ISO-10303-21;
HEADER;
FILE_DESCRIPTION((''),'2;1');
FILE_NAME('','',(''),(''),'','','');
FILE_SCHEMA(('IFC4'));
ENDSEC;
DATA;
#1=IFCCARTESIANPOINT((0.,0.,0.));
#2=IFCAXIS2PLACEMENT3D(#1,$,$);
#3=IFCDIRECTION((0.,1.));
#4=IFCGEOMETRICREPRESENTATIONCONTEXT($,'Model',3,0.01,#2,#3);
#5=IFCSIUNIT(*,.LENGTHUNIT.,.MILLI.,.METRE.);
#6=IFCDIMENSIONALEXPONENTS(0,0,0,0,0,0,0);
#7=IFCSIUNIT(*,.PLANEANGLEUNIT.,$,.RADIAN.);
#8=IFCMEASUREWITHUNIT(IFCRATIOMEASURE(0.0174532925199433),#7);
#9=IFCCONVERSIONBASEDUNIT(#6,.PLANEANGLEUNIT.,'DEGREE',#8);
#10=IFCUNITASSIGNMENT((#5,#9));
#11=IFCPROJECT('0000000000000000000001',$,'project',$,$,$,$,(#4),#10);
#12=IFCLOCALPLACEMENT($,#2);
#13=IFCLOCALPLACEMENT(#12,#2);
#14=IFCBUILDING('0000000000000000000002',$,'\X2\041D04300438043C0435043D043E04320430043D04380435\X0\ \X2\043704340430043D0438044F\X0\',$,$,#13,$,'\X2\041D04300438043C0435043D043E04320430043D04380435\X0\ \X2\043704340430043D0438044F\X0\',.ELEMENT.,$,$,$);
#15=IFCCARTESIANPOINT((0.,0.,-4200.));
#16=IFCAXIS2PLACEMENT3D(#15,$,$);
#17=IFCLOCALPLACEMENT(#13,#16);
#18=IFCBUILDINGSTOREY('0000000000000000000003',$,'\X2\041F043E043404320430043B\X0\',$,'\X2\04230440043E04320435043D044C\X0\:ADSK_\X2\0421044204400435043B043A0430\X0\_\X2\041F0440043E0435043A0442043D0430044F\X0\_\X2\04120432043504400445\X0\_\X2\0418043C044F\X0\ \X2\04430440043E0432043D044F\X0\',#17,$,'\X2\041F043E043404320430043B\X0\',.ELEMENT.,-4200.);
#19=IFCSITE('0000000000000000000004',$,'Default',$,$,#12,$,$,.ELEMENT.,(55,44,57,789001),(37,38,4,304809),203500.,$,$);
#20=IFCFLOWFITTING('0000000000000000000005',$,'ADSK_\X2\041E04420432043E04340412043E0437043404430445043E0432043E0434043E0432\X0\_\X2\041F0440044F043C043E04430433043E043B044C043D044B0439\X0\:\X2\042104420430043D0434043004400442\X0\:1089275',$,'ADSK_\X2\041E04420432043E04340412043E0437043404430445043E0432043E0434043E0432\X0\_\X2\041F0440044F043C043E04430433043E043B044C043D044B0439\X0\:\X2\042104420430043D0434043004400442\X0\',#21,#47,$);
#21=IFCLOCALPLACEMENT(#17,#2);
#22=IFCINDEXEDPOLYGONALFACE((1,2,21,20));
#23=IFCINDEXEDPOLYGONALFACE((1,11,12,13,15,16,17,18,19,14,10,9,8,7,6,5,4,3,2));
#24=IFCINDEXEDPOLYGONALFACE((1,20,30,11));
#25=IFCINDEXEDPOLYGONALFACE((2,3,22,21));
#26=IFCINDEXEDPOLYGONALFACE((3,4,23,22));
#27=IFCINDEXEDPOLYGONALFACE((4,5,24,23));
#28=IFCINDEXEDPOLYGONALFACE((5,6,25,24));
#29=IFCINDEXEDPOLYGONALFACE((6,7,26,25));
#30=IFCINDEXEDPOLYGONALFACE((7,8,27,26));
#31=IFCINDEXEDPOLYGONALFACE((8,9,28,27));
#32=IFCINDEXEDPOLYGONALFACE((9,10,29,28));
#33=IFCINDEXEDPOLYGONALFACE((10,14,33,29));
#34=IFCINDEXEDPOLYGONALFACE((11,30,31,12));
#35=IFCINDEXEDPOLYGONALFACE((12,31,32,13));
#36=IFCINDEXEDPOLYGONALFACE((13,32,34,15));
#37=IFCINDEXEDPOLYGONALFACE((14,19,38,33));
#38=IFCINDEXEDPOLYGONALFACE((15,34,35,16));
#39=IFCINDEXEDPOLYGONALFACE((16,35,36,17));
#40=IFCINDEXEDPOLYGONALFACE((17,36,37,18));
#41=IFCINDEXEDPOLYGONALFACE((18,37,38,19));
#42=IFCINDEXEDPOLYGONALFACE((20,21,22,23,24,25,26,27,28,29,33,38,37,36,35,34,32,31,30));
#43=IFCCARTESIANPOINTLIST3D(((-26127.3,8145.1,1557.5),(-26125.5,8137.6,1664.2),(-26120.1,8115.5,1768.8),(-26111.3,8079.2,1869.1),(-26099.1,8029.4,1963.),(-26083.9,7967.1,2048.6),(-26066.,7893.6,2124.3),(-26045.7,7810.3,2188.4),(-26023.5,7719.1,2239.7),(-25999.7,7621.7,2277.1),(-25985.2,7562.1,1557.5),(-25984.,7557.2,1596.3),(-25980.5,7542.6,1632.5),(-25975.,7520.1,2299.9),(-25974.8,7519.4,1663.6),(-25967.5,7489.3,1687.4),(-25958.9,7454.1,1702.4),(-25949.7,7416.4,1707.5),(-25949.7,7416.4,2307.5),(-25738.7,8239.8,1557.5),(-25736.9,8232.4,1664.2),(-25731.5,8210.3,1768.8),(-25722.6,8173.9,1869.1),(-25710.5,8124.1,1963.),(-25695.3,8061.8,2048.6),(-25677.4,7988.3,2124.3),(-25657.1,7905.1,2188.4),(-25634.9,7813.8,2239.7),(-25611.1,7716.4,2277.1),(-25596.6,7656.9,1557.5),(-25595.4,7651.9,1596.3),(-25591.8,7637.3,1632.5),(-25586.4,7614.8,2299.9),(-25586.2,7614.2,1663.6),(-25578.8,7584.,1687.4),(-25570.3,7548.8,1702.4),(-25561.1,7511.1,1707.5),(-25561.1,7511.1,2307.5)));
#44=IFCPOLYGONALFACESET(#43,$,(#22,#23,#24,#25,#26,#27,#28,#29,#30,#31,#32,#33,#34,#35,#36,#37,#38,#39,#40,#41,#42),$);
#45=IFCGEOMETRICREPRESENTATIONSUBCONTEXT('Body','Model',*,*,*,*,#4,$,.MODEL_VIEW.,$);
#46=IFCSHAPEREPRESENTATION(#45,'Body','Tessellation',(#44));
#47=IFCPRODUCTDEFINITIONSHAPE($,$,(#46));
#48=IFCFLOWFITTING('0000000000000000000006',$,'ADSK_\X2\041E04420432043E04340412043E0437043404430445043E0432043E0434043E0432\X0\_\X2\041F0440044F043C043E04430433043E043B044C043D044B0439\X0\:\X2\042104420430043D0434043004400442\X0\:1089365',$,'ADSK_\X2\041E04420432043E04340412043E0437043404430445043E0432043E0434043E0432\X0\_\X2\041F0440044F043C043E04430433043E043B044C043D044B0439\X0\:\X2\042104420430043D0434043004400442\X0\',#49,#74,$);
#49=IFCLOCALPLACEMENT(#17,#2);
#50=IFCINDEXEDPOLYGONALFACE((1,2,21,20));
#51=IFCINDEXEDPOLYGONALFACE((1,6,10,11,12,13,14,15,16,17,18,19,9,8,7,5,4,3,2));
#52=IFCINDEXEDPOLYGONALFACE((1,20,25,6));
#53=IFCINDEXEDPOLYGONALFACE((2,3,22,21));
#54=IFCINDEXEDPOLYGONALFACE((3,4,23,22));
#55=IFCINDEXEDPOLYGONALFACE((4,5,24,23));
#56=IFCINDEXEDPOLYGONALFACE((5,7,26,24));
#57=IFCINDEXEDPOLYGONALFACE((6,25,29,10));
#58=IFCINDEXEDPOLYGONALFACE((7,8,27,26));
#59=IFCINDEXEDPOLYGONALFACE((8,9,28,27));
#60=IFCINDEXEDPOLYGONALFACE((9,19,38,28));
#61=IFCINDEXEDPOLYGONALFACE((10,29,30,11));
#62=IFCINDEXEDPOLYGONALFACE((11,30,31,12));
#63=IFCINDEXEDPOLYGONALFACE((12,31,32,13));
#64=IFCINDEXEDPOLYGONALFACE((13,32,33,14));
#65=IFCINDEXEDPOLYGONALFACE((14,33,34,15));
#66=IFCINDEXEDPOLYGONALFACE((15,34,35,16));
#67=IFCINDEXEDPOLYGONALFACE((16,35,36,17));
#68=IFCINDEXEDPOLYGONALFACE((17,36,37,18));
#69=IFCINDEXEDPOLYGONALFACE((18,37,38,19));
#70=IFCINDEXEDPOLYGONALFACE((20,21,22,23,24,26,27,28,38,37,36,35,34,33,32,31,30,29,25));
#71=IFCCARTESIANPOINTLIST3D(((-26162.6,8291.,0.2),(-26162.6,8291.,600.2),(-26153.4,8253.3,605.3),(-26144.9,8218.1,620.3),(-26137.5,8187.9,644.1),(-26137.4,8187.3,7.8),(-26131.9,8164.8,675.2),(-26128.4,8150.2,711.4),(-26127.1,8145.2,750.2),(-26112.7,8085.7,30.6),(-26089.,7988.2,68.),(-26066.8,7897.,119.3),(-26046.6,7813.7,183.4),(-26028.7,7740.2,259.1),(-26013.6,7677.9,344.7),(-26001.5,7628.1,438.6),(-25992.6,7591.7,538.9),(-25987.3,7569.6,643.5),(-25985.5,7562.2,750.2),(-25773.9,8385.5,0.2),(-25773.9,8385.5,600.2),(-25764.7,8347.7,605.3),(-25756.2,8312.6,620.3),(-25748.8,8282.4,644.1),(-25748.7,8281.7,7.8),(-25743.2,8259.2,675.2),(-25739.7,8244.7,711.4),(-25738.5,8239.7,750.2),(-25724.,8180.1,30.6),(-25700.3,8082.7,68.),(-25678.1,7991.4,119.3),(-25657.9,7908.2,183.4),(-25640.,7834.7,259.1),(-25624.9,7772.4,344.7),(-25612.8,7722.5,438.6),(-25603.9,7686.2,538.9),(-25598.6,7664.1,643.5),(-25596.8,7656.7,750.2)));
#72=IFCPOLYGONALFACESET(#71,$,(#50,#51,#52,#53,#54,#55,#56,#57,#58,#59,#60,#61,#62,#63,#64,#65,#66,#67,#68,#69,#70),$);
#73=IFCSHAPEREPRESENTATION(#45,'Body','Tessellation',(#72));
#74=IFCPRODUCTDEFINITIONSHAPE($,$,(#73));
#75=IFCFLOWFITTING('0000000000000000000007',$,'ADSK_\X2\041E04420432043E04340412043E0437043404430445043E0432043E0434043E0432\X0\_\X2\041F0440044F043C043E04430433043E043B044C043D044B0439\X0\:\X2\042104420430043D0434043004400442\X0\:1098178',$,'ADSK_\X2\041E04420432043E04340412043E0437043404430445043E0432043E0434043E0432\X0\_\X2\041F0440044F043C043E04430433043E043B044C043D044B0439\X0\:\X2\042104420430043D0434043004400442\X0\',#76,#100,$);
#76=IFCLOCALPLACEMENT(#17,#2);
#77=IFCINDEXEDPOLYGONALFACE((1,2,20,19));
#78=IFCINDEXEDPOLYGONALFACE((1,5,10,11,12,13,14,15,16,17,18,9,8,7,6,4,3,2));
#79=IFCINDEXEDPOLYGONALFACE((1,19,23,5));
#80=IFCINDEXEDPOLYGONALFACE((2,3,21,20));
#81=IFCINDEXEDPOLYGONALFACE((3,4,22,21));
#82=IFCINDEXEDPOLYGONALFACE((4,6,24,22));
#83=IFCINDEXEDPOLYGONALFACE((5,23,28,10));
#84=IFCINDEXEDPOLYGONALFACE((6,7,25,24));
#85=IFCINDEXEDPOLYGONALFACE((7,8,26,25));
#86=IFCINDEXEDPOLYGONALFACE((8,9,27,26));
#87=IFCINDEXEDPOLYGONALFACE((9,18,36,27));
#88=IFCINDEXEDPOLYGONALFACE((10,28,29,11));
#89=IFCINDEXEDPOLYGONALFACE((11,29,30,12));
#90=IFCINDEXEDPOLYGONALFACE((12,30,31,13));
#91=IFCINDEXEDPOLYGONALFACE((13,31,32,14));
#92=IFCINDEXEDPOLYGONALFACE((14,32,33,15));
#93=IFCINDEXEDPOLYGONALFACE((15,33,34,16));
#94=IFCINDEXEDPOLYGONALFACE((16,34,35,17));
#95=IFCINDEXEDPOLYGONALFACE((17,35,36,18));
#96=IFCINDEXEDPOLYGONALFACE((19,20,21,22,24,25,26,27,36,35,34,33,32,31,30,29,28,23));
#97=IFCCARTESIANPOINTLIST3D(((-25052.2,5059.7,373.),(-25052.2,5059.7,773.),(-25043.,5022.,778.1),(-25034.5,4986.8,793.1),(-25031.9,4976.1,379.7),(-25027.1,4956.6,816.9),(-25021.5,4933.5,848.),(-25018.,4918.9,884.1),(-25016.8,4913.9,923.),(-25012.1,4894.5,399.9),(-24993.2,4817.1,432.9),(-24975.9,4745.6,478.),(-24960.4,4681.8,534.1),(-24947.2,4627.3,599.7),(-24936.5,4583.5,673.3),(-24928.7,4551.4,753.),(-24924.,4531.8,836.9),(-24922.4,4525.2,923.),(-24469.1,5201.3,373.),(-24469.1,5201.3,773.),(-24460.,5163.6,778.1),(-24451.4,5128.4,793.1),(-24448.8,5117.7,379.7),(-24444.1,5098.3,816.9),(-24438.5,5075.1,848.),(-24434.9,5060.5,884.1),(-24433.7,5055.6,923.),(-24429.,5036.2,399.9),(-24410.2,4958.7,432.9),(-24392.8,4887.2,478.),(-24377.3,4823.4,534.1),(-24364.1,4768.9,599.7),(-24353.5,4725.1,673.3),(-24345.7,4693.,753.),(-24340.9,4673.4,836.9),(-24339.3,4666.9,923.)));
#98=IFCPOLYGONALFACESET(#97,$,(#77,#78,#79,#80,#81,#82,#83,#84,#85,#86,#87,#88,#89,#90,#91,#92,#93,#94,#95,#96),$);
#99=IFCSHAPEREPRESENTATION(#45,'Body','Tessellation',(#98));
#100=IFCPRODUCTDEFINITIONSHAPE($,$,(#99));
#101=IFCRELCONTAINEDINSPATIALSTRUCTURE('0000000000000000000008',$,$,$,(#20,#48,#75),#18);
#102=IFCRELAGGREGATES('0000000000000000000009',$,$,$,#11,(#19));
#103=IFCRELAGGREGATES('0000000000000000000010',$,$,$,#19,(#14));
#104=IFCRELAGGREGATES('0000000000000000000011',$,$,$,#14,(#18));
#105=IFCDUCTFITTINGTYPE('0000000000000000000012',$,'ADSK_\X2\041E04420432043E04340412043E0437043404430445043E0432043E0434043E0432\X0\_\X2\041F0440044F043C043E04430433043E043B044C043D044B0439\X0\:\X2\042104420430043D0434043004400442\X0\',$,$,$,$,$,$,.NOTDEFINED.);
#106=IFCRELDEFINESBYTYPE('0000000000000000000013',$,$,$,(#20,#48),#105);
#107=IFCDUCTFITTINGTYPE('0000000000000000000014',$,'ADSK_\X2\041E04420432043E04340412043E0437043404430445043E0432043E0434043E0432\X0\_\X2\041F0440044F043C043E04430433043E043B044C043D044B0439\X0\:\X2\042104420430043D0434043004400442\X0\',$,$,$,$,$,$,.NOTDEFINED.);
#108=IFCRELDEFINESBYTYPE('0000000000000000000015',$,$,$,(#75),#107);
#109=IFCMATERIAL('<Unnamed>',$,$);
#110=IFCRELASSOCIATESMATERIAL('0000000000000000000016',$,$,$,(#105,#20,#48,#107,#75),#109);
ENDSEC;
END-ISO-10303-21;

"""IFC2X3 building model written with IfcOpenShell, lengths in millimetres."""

from ifc_helpers import new_model, entity, si_unit, converted_unit, direction, frame, frame_2d, origin, place, context, subcontext, project, spatial, polyline, circle_curve, parameter, trimmed, segment, composite_curve, outline, extrude, source, transform, mapped, material, type_object, type_shapes, element, save


model = new_model("IFC2X3")

# Units and contexts
model_context = context("Model", 3, precision=0.01, world=origin(), true_north=direction((0.0, 1.0)))
body_context = subcontext(model_context, "Body", "Model", "MODEL_VIEW")
ifc_project = project(units=[si_unit("LENGTHUNIT", "METRE", prefix="MILLI"), converted_unit("PLANEANGLEUNIT", "DEGREE", entity("IfcRatioMeasure", 0.0174532925199433), si_unit("PLANEANGLEUNIT", "RADIAN"), dimensions=[0, 0, 0, 0, 0, 0, 0])], contexts=[model_context])

# Site, building, storey
site_placement = place(None, frame((0.0, 0.0, 0.0)))
site = spatial("IfcSite", under=ifc_project, at=site_placement, Name="Default", CompositionType="ELEMENT", RefLatitude=(55, 44, 57, 789001), RefLongitude=(37, 38, 4, 304809), RefElevation=203500.0)
building_placement = place(site_placement, origin())
building = spatial("IfcBuilding", under=site, at=building_placement, Name="Наименование здания", LongName="Наименование здания", CompositionType="ELEMENT")
storey_placement = place(building_placement, frame((0.0, 0.0, -4200.0)))
storey = spatial("IfcBuildingStorey", under=building, at=storey_placement, Name="Подвал", ObjectType="Уровень:ADSK_Стрелка_Проектная_Вверх_Имя уровня", LongName="Подвал", CompositionType="ELEMENT", Elevation=-4200.0)

# Shared definitions
ifc_material_1 = material(Name="<Unnamed>")

# Flow fittings
duct_fitting_type_1 = type_object("IfcDuctFittingType", Name="ADSK_ОтводВоздуховодов_Прямоугольный:Стандарт", PredefinedType="NOTDEFINED", material=ifc_material_1)
shared_shape_1 = source(origin(), body_context, "Body", "SweptSolid", [
    extrude(outline(composite_curve([segment(polyline([(-525.0, -225.0), (75.0, -225.0)]), True, "CONTINUOUS"), segment(trimmed(circle_curve(frame_2d((225.0, -225.0), x_axis=(0.0, 1.0)), 150.0), [parameter(0.0)], [parameter(90.0)], True, "PARAMETER"), False, "CONTINUOUS"), segment(polyline([(225.0, -75.0), (225.0, 525.0)]), True, "CONTINUOUS"), segment(trimmed(circle_curve(frame_2d((225.0, -225.0), x_axis=(0.0, 1.0)), 750.0), [parameter(0.0)], [parameter(90.0)], True, "PARAMETER"), True, "CONTINUOUS")], self_intersect=False)), frame((-225.0, 225.0, -200.0), z_axis=(0.0, 0.0, 1.0), x_axis=(-1.0, 0.0, 0.0)), (0.0, 0.0, 1.0), 400.0),
])
type_shapes(duct_fitting_type_1, [shared_shape_1])
for number, where, z_axis, x_axis, name in (
    (1, (-25862.0, 7901.0, 2007.5), (-0.971553, -0.236821, 0.0), (-0.236821, 0.971553, 0.0), "ADSK_ОтводВоздуховодов_Прямоугольный:Стандарт:1089275"),
    (2, (-25862.0, 7901.0, 300.2), (0.971714, 0.23616, 0.0), (0.0, 0.0, -1.0), "ADSK_ОтводВоздуховодов_Прямоугольный:Стандарт:1089365"),
):
    element("IfcFlowFitting", number, at=place(storey_placement, frame(where, z_axis=z_axis, x_axis=x_axis)), inside=storey, type_object=duct_fitting_type_1, material=ifc_material_1, Name=name, ObjectType="ADSK_ОтводВоздуховодов_Прямоугольный:Стандарт", context=body_context, shape_type="MappedRepresentation", body=[
        mapped(shared_shape_1, transform((0.0, 0.0, 0.0), scale=1.0)),
    ])
duct_fitting_type_2 = type_object("IfcDuctFittingType", Name="ADSK_ОтводВоздуховодов_Прямоугольный:Стандарт", PredefinedType="NOTDEFINED", material=ifc_material_1)
shared_shape_2 = source(origin(), body_context, "Body", "SweptSolid", [
    extrude(outline(composite_curve([segment(polyline([(-375.0, -175.0), (25.0, -175.0)]), True, "CONTINUOUS"), segment(trimmed(circle_curve(frame_2d((175.0, -175.0), x_axis=(0.0, 1.0)), 150.0), [parameter(0.0)], [parameter(90.0)], True, "PARAMETER"), False, "CONTINUOUS"), segment(polyline([(175.0, -25.0), (175.0, 375.0)]), True, "CONTINUOUS"), segment(trimmed(circle_curve(frame_2d((175.0, -175.0), x_axis=(0.0, 1.0)), 550.0), [parameter(0.0)], [parameter(90.0)], True, "PARAMETER"), True, "CONTINUOUS")], self_intersect=False)), frame((-175.0, 175.0, -300.0), z_axis=(0.0, 0.0, 1.0), x_axis=(-1.0, 0.0, 0.0)), (0.0, 0.0, 1.0), 600.0),
])
type_shapes(duct_fitting_type_2, [shared_shape_2])
flow_fitting_1_placement = place(storey_placement, frame((-24678.0, 4790.4, 573.0), z_axis=(-0.971743, -0.23604, 0.0), x_axis=(0.23604, -0.971743, 0.0)))
element("IfcFlowFitting", 3, at=flow_fitting_1_placement, inside=storey, type_object=duct_fitting_type_2, material=ifc_material_1, Name="ADSK_ОтводВоздуховодов_Прямоугольный:Стандарт:1098178", ObjectType="ADSK_ОтводВоздуховодов_Прямоугольный:Стандарт", context=body_context, shape_type="MappedRepresentation", body=[
    mapped(shared_shape_2, transform((0.0, 0.0, 0.0), scale=1.0)),
])

save(model, "model.ifc")
